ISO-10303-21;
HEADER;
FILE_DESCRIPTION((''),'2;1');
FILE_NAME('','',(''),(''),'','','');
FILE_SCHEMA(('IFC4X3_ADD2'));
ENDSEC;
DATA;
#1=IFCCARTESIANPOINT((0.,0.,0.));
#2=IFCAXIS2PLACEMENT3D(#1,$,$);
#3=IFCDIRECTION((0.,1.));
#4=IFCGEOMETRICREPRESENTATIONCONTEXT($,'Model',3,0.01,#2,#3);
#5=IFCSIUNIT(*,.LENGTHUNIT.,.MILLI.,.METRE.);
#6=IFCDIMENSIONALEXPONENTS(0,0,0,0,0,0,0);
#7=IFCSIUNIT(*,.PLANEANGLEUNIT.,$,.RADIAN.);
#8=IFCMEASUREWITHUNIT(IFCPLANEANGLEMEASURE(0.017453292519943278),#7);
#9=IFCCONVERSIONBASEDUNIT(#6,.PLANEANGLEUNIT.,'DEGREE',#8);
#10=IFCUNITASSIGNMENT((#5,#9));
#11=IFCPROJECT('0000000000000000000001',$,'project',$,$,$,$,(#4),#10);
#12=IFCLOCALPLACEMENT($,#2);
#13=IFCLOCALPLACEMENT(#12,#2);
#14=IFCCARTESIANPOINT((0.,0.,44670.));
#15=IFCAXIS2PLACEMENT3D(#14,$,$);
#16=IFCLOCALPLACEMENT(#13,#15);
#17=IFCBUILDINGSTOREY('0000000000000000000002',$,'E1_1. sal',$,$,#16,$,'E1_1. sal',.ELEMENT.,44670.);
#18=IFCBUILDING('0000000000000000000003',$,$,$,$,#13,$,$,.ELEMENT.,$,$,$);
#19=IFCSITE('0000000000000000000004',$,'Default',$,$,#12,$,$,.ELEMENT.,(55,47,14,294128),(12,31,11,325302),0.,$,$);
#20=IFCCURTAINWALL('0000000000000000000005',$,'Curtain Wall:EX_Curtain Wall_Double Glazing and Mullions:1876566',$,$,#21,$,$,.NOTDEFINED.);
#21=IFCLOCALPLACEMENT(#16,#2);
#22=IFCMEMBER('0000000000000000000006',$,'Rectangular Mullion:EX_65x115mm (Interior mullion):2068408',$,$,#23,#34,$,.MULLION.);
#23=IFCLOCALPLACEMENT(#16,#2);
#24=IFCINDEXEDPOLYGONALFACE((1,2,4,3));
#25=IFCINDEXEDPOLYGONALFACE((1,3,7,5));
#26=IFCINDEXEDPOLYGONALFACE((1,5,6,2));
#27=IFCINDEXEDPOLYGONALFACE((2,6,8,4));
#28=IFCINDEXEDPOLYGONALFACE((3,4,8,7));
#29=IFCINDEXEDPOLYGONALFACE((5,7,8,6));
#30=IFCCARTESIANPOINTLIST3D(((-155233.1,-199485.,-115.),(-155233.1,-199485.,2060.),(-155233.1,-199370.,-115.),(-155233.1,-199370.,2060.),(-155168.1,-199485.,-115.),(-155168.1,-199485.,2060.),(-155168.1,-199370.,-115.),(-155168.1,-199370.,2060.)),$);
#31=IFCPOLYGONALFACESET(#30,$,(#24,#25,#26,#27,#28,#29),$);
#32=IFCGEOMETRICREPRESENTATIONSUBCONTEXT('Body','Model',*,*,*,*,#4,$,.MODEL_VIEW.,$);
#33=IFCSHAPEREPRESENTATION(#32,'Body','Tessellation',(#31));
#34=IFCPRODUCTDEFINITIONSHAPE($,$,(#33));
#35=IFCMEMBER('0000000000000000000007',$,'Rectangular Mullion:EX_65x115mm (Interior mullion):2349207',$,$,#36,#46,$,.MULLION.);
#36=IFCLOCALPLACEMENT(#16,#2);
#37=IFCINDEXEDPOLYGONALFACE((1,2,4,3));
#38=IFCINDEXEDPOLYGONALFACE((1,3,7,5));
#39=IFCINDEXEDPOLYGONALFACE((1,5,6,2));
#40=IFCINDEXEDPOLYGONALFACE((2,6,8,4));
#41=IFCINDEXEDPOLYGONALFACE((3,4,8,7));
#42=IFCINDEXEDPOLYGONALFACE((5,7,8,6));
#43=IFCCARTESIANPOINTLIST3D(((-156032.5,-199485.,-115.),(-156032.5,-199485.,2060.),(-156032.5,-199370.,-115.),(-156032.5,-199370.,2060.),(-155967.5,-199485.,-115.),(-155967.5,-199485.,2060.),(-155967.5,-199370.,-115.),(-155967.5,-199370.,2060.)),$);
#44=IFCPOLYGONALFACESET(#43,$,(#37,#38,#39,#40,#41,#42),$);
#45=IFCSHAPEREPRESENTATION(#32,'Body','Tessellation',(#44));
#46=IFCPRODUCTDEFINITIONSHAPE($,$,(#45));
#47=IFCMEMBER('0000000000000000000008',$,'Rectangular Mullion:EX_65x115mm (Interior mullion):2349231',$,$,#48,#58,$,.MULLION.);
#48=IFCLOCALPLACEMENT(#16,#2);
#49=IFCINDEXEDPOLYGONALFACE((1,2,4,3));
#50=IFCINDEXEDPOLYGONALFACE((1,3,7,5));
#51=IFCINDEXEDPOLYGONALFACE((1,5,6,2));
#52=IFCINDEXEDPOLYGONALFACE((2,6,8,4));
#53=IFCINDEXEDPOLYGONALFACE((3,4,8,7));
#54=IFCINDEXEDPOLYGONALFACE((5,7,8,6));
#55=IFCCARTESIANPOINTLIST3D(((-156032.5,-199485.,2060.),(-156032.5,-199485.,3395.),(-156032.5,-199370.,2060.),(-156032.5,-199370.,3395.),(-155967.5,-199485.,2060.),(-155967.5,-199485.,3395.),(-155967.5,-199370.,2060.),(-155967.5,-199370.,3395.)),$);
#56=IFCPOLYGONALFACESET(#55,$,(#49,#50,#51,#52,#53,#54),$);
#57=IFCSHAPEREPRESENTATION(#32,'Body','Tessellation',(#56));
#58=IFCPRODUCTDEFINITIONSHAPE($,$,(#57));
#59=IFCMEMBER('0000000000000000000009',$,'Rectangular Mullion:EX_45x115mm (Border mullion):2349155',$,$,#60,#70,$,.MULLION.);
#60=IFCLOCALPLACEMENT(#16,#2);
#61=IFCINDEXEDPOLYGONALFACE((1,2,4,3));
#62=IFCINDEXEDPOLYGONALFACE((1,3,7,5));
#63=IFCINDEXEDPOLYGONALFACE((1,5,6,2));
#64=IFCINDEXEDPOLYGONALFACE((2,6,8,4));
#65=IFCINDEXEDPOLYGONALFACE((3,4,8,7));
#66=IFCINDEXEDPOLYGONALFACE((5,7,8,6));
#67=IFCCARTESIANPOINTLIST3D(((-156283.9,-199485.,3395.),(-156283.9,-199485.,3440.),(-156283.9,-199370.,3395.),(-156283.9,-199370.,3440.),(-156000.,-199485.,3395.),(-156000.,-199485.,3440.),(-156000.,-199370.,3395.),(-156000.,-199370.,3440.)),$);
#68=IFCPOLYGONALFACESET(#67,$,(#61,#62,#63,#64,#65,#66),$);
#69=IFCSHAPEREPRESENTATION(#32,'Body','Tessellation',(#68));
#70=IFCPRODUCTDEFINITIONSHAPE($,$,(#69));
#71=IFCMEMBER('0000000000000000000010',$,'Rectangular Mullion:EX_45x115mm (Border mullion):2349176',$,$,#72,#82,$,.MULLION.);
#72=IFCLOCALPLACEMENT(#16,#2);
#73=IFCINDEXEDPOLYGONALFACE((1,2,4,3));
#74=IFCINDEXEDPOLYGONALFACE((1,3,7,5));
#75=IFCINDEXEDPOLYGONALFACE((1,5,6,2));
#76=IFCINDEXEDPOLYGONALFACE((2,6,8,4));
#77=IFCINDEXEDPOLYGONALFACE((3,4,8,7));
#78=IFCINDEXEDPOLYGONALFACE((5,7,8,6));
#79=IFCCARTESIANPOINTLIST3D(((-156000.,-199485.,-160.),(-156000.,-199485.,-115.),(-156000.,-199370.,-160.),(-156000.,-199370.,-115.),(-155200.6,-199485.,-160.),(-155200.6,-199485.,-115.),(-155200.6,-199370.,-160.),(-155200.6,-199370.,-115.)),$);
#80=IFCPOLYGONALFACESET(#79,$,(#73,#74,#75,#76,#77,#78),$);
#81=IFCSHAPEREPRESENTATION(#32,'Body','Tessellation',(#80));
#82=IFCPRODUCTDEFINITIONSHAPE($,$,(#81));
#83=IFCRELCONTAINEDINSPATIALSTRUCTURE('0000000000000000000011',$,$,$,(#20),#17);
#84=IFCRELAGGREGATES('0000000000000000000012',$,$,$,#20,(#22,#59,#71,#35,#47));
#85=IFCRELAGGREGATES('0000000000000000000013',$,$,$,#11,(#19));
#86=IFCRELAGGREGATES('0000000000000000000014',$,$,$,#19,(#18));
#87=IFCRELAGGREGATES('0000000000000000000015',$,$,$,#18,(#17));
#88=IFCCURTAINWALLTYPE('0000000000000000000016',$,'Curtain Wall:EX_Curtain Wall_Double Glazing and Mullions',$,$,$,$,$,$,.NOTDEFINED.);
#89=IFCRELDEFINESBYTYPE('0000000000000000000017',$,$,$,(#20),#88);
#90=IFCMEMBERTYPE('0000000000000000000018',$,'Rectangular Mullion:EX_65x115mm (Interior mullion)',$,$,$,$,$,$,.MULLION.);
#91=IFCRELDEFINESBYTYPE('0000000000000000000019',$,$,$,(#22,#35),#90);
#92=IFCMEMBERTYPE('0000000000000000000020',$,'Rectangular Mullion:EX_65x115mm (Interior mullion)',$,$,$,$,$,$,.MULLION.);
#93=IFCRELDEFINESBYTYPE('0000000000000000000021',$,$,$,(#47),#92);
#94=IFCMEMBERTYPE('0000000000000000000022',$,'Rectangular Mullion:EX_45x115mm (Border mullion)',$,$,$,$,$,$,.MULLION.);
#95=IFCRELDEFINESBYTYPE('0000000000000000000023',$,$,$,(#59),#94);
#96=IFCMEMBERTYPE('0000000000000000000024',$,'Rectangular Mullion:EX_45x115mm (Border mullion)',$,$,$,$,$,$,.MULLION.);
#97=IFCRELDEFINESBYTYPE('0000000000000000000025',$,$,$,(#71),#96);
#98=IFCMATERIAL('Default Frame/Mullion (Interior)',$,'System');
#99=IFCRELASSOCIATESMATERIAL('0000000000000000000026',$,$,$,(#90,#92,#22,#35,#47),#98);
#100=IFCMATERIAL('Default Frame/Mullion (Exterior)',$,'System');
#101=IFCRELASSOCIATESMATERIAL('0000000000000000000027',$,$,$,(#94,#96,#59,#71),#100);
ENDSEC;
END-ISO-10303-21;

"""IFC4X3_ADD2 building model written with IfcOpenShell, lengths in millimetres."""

from ifc_helpers import new_model, entity, si_unit, converted_unit, direction, frame, origin, origin_2d_with_axis, place, context, subcontext, project, spatial, rectangle, extrude, source, transform, mapped, material, material_profile, profile_set, profile_usage, type_object, type_shapes, element, aggregate, save


model = new_model("IFC4X3_ADD2")

# Units and contexts
model_context = context("Model", 3, precision=0.01, world=origin(), true_north=direction((0.0, 1.0)))
body_context = subcontext(model_context, "Body", "Model", "MODEL_VIEW")
ifc_project = project(units=[si_unit("LENGTHUNIT", "METRE", prefix="MILLI"), converted_unit("PLANEANGLEUNIT", "DEGREE", entity("IfcPlaneAngleMeasure", 0.017453292519943278), si_unit("PLANEANGLEUNIT", "RADIAN"), dimensions=[0, 0, 0, 0, 0, 0, 0])], contexts=[model_context])

# Site, building, storey
site_placement = place(None, origin())
site = spatial("IfcSite", under=ifc_project, at=site_placement, Name="Default", CompositionType="ELEMENT", RefLatitude=(55, 47, 14, 294128), RefLongitude=(12, 31, 11, 325302), RefElevation=0.0)
building_placement = place(site_placement, origin())
building = spatial("IfcBuilding", under=site, at=building_placement, CompositionType="ELEMENT")
storey_placement = place(building_placement, frame((0.0, 0.0, 44670.0)))
storey = spatial("IfcBuildingStorey", under=building, at=storey_placement, Name="E1_1. sal", LongName="E1_1. sal", CompositionType="ELEMENT", Elevation=44670.0)

# Curtain wall, members
curtain_wall_type = type_object("IfcCurtainWallType", Name="Curtain Wall:EX_Curtain Wall_Double Glazing and Mullions", PredefinedType="NOTDEFINED")
curtain_wall_placement = place(storey_placement, frame((0.0, 0.0, -44670.0)))
curtain_wall = element("IfcCurtainWall", 1, at=curtain_wall_placement, inside=storey, type_object=curtain_wall_type, Name="Curtain Wall:EX_Curtain Wall_Double Glazing and Mullions:1876566", PredefinedType="NOTDEFINED")
ifc_material_1 = material(Name="Default Frame/Mullion (Interior)", Category="System")
ifc_material_profile_1 = material_profile(ifc_material_1, rectangle(XDim=65.0, YDim=115.0, at=origin_2d_with_axis()), Name="EX_65x115mm (Interior mullion)")
ifc_profile_set_1 = profile_set([ifc_material_profile_1], Name="EX_65x115mm (Interior mullion)")
ifc_profile_usage_1 = profile_usage(ifc_profile_set_1)
member_type_1 = type_object("IfcMemberType", Name="Rectangular Mullion:EX_65x115mm (Interior mullion)", PredefinedType="MULLION", material=ifc_profile_set_1)
shared_shape_1 = source(origin(), body_context, "Body", "SweptSolid", [
    extrude(rectangle(XDim=65.0, YDim=115.0, at=origin_2d_with_axis()), frame((0.0, -57.5, -2175.0), z_axis=(0.0, 0.0, 1.0), x_axis=(-1.0, 0.0, 0.0)), (0.0, 0.0, 1.0), 2175.0),
])
type_shapes(member_type_1, [shared_shape_1])
member_1_placement = place(curtain_wall_placement, frame((-155200.6, -199485.0, 44555.0), z_axis=(0.0, 0.0, -1.0), x_axis=(1.0, 0.0, 0.0)))
member_1 = element("IfcMember", 2, at=member_1_placement, type_object=member_type_1, material=ifc_profile_usage_1, Name="Rectangular Mullion:EX_65x115mm (Interior mullion):2068408", PredefinedType="MULLION", context=body_context, shape_type="MappedRepresentation", body=[
    mapped(shared_shape_1, transform((0.0, 0.0, 0.0), scale=1.0)),
])
member_2_placement = place(curtain_wall_placement, frame((-156000.0, -199485.0, 44555.0), z_axis=(0.0, 0.0, -1.0), x_axis=(1.0, 0.0, 0.0)))
member_2 = element("IfcMember", 3, at=member_2_placement, type_object=member_type_1, material=ifc_profile_usage_1, Name="Rectangular Mullion:EX_65x115mm (Interior mullion):2349207", PredefinedType="MULLION", context=body_context, shape_type="MappedRepresentation", body=[
    mapped(shared_shape_1, transform((0.0, 0.0, 0.0), scale=1.0)),
])
member_type_2 = type_object("IfcMemberType", Name="Rectangular Mullion:EX_65x115mm (Interior mullion)", PredefinedType="MULLION", material=ifc_profile_set_1)
shared_shape_2 = source(origin(), body_context, "Body", "SweptSolid", [
    extrude(rectangle(XDim=65.0, YDim=115.0, at=origin_2d_with_axis()), frame((0.0, -57.5, -1335.0), z_axis=(0.0, 0.0, 1.0), x_axis=(-1.0, 0.0, 0.0)), (0.0, 0.0, 1.0), 1335.0),
])
type_shapes(member_type_2, [shared_shape_2])
member_3_placement = place(curtain_wall_placement, frame((-156000.0, -199485.0, 46730.0), z_axis=(0.0, 0.0, -1.0), x_axis=(1.0, 0.0, 0.0)))
member_3 = element("IfcMember", 4, at=member_3_placement, type_object=member_type_2, material=ifc_profile_usage_1, Name="Rectangular Mullion:EX_65x115mm (Interior mullion):2349231", PredefinedType="MULLION", context=body_context, shape_type="MappedRepresentation", body=[
    mapped(shared_shape_2, transform((0.0, 0.0, 0.0), scale=1.0)),
])
ifc_material_2 = material(Name="Default Frame/Mullion (Exterior)", Category="System")
ifc_material_profile_2 = material_profile(ifc_material_2, rectangle(XDim=45.0, YDim=115.0, at=origin_2d_with_axis()), Name="EX_45x115mm (Border mullion)")
ifc_profile_set_2 = profile_set([ifc_material_profile_2], Name="EX_45x115mm (Border mullion)")
ifc_profile_usage_2 = profile_usage(ifc_profile_set_2)
member_type_3 = type_object("IfcMemberType", Name="Rectangular Mullion:EX_45x115mm (Border mullion)", PredefinedType="MULLION", material=ifc_profile_set_2)
shared_shape_3 = source(origin(), body_context, "Body", "SweptSolid", [
    extrude(rectangle(XDim=45.0, YDim=115.0, at=origin_2d_with_axis()), frame((-22.5, -57.5, -283.9), z_axis=(0.0, 0.0, 1.0), x_axis=(-1.0, 0.0, 0.0)), (0.0, 0.0, 1.0), 283.9),
])
type_shapes(member_type_3, [shared_shape_3])
member_4_placement = place(curtain_wall_placement, frame((-156000.0, -199485.0, 48110.0), z_axis=(1.0, 0.0, 0.0), x_axis=(0.0, 0.0, 1.0)))
member_4 = element("IfcMember", 5, at=member_4_placement, type_object=member_type_3, material=ifc_profile_usage_2, Name="Rectangular Mullion:EX_45x115mm (Border mullion):2349155", PredefinedType="MULLION", context=body_context, shape_type="MappedRepresentation", body=[
    mapped(shared_shape_3, transform((0.0, 0.0, 0.0), scale=1.0)),
])
member_type_4 = type_object("IfcMemberType", Name="Rectangular Mullion:EX_45x115mm (Border mullion)", PredefinedType="MULLION", material=ifc_profile_set_2)
shared_shape_4 = source(origin(), body_context, "Body", "SweptSolid", [
    extrude(rectangle(XDim=45.0, YDim=115.0, at=origin_2d_with_axis()), frame((-22.5, -57.5, -799.4), z_axis=(0.0, 0.0, 1.0), x_axis=(-1.0, 0.0, 0.0)), (0.0, 0.0, 1.0), 799.4),
])
type_shapes(member_type_4, [shared_shape_4])
member_5_placement = place(curtain_wall_placement, frame((-156000.0, -199485.0, 44510.0), z_axis=(-1.0, 0.0, 0.0), x_axis=(0.0, 0.0, -1.0)))
member_5 = element("IfcMember", 6, at=member_5_placement, type_object=member_type_4, material=ifc_profile_usage_2, Name="Rectangular Mullion:EX_45x115mm (Border mullion):2349176", PredefinedType="MULLION", context=body_context, shape_type="MappedRepresentation", body=[
    mapped(shared_shape_4, transform((0.0, 0.0, 0.0), scale=1.0)),
])
aggregate(curtain_wall, [member_1, member_4, member_5, member_2, member_3])

save(model, "model.ifc")
